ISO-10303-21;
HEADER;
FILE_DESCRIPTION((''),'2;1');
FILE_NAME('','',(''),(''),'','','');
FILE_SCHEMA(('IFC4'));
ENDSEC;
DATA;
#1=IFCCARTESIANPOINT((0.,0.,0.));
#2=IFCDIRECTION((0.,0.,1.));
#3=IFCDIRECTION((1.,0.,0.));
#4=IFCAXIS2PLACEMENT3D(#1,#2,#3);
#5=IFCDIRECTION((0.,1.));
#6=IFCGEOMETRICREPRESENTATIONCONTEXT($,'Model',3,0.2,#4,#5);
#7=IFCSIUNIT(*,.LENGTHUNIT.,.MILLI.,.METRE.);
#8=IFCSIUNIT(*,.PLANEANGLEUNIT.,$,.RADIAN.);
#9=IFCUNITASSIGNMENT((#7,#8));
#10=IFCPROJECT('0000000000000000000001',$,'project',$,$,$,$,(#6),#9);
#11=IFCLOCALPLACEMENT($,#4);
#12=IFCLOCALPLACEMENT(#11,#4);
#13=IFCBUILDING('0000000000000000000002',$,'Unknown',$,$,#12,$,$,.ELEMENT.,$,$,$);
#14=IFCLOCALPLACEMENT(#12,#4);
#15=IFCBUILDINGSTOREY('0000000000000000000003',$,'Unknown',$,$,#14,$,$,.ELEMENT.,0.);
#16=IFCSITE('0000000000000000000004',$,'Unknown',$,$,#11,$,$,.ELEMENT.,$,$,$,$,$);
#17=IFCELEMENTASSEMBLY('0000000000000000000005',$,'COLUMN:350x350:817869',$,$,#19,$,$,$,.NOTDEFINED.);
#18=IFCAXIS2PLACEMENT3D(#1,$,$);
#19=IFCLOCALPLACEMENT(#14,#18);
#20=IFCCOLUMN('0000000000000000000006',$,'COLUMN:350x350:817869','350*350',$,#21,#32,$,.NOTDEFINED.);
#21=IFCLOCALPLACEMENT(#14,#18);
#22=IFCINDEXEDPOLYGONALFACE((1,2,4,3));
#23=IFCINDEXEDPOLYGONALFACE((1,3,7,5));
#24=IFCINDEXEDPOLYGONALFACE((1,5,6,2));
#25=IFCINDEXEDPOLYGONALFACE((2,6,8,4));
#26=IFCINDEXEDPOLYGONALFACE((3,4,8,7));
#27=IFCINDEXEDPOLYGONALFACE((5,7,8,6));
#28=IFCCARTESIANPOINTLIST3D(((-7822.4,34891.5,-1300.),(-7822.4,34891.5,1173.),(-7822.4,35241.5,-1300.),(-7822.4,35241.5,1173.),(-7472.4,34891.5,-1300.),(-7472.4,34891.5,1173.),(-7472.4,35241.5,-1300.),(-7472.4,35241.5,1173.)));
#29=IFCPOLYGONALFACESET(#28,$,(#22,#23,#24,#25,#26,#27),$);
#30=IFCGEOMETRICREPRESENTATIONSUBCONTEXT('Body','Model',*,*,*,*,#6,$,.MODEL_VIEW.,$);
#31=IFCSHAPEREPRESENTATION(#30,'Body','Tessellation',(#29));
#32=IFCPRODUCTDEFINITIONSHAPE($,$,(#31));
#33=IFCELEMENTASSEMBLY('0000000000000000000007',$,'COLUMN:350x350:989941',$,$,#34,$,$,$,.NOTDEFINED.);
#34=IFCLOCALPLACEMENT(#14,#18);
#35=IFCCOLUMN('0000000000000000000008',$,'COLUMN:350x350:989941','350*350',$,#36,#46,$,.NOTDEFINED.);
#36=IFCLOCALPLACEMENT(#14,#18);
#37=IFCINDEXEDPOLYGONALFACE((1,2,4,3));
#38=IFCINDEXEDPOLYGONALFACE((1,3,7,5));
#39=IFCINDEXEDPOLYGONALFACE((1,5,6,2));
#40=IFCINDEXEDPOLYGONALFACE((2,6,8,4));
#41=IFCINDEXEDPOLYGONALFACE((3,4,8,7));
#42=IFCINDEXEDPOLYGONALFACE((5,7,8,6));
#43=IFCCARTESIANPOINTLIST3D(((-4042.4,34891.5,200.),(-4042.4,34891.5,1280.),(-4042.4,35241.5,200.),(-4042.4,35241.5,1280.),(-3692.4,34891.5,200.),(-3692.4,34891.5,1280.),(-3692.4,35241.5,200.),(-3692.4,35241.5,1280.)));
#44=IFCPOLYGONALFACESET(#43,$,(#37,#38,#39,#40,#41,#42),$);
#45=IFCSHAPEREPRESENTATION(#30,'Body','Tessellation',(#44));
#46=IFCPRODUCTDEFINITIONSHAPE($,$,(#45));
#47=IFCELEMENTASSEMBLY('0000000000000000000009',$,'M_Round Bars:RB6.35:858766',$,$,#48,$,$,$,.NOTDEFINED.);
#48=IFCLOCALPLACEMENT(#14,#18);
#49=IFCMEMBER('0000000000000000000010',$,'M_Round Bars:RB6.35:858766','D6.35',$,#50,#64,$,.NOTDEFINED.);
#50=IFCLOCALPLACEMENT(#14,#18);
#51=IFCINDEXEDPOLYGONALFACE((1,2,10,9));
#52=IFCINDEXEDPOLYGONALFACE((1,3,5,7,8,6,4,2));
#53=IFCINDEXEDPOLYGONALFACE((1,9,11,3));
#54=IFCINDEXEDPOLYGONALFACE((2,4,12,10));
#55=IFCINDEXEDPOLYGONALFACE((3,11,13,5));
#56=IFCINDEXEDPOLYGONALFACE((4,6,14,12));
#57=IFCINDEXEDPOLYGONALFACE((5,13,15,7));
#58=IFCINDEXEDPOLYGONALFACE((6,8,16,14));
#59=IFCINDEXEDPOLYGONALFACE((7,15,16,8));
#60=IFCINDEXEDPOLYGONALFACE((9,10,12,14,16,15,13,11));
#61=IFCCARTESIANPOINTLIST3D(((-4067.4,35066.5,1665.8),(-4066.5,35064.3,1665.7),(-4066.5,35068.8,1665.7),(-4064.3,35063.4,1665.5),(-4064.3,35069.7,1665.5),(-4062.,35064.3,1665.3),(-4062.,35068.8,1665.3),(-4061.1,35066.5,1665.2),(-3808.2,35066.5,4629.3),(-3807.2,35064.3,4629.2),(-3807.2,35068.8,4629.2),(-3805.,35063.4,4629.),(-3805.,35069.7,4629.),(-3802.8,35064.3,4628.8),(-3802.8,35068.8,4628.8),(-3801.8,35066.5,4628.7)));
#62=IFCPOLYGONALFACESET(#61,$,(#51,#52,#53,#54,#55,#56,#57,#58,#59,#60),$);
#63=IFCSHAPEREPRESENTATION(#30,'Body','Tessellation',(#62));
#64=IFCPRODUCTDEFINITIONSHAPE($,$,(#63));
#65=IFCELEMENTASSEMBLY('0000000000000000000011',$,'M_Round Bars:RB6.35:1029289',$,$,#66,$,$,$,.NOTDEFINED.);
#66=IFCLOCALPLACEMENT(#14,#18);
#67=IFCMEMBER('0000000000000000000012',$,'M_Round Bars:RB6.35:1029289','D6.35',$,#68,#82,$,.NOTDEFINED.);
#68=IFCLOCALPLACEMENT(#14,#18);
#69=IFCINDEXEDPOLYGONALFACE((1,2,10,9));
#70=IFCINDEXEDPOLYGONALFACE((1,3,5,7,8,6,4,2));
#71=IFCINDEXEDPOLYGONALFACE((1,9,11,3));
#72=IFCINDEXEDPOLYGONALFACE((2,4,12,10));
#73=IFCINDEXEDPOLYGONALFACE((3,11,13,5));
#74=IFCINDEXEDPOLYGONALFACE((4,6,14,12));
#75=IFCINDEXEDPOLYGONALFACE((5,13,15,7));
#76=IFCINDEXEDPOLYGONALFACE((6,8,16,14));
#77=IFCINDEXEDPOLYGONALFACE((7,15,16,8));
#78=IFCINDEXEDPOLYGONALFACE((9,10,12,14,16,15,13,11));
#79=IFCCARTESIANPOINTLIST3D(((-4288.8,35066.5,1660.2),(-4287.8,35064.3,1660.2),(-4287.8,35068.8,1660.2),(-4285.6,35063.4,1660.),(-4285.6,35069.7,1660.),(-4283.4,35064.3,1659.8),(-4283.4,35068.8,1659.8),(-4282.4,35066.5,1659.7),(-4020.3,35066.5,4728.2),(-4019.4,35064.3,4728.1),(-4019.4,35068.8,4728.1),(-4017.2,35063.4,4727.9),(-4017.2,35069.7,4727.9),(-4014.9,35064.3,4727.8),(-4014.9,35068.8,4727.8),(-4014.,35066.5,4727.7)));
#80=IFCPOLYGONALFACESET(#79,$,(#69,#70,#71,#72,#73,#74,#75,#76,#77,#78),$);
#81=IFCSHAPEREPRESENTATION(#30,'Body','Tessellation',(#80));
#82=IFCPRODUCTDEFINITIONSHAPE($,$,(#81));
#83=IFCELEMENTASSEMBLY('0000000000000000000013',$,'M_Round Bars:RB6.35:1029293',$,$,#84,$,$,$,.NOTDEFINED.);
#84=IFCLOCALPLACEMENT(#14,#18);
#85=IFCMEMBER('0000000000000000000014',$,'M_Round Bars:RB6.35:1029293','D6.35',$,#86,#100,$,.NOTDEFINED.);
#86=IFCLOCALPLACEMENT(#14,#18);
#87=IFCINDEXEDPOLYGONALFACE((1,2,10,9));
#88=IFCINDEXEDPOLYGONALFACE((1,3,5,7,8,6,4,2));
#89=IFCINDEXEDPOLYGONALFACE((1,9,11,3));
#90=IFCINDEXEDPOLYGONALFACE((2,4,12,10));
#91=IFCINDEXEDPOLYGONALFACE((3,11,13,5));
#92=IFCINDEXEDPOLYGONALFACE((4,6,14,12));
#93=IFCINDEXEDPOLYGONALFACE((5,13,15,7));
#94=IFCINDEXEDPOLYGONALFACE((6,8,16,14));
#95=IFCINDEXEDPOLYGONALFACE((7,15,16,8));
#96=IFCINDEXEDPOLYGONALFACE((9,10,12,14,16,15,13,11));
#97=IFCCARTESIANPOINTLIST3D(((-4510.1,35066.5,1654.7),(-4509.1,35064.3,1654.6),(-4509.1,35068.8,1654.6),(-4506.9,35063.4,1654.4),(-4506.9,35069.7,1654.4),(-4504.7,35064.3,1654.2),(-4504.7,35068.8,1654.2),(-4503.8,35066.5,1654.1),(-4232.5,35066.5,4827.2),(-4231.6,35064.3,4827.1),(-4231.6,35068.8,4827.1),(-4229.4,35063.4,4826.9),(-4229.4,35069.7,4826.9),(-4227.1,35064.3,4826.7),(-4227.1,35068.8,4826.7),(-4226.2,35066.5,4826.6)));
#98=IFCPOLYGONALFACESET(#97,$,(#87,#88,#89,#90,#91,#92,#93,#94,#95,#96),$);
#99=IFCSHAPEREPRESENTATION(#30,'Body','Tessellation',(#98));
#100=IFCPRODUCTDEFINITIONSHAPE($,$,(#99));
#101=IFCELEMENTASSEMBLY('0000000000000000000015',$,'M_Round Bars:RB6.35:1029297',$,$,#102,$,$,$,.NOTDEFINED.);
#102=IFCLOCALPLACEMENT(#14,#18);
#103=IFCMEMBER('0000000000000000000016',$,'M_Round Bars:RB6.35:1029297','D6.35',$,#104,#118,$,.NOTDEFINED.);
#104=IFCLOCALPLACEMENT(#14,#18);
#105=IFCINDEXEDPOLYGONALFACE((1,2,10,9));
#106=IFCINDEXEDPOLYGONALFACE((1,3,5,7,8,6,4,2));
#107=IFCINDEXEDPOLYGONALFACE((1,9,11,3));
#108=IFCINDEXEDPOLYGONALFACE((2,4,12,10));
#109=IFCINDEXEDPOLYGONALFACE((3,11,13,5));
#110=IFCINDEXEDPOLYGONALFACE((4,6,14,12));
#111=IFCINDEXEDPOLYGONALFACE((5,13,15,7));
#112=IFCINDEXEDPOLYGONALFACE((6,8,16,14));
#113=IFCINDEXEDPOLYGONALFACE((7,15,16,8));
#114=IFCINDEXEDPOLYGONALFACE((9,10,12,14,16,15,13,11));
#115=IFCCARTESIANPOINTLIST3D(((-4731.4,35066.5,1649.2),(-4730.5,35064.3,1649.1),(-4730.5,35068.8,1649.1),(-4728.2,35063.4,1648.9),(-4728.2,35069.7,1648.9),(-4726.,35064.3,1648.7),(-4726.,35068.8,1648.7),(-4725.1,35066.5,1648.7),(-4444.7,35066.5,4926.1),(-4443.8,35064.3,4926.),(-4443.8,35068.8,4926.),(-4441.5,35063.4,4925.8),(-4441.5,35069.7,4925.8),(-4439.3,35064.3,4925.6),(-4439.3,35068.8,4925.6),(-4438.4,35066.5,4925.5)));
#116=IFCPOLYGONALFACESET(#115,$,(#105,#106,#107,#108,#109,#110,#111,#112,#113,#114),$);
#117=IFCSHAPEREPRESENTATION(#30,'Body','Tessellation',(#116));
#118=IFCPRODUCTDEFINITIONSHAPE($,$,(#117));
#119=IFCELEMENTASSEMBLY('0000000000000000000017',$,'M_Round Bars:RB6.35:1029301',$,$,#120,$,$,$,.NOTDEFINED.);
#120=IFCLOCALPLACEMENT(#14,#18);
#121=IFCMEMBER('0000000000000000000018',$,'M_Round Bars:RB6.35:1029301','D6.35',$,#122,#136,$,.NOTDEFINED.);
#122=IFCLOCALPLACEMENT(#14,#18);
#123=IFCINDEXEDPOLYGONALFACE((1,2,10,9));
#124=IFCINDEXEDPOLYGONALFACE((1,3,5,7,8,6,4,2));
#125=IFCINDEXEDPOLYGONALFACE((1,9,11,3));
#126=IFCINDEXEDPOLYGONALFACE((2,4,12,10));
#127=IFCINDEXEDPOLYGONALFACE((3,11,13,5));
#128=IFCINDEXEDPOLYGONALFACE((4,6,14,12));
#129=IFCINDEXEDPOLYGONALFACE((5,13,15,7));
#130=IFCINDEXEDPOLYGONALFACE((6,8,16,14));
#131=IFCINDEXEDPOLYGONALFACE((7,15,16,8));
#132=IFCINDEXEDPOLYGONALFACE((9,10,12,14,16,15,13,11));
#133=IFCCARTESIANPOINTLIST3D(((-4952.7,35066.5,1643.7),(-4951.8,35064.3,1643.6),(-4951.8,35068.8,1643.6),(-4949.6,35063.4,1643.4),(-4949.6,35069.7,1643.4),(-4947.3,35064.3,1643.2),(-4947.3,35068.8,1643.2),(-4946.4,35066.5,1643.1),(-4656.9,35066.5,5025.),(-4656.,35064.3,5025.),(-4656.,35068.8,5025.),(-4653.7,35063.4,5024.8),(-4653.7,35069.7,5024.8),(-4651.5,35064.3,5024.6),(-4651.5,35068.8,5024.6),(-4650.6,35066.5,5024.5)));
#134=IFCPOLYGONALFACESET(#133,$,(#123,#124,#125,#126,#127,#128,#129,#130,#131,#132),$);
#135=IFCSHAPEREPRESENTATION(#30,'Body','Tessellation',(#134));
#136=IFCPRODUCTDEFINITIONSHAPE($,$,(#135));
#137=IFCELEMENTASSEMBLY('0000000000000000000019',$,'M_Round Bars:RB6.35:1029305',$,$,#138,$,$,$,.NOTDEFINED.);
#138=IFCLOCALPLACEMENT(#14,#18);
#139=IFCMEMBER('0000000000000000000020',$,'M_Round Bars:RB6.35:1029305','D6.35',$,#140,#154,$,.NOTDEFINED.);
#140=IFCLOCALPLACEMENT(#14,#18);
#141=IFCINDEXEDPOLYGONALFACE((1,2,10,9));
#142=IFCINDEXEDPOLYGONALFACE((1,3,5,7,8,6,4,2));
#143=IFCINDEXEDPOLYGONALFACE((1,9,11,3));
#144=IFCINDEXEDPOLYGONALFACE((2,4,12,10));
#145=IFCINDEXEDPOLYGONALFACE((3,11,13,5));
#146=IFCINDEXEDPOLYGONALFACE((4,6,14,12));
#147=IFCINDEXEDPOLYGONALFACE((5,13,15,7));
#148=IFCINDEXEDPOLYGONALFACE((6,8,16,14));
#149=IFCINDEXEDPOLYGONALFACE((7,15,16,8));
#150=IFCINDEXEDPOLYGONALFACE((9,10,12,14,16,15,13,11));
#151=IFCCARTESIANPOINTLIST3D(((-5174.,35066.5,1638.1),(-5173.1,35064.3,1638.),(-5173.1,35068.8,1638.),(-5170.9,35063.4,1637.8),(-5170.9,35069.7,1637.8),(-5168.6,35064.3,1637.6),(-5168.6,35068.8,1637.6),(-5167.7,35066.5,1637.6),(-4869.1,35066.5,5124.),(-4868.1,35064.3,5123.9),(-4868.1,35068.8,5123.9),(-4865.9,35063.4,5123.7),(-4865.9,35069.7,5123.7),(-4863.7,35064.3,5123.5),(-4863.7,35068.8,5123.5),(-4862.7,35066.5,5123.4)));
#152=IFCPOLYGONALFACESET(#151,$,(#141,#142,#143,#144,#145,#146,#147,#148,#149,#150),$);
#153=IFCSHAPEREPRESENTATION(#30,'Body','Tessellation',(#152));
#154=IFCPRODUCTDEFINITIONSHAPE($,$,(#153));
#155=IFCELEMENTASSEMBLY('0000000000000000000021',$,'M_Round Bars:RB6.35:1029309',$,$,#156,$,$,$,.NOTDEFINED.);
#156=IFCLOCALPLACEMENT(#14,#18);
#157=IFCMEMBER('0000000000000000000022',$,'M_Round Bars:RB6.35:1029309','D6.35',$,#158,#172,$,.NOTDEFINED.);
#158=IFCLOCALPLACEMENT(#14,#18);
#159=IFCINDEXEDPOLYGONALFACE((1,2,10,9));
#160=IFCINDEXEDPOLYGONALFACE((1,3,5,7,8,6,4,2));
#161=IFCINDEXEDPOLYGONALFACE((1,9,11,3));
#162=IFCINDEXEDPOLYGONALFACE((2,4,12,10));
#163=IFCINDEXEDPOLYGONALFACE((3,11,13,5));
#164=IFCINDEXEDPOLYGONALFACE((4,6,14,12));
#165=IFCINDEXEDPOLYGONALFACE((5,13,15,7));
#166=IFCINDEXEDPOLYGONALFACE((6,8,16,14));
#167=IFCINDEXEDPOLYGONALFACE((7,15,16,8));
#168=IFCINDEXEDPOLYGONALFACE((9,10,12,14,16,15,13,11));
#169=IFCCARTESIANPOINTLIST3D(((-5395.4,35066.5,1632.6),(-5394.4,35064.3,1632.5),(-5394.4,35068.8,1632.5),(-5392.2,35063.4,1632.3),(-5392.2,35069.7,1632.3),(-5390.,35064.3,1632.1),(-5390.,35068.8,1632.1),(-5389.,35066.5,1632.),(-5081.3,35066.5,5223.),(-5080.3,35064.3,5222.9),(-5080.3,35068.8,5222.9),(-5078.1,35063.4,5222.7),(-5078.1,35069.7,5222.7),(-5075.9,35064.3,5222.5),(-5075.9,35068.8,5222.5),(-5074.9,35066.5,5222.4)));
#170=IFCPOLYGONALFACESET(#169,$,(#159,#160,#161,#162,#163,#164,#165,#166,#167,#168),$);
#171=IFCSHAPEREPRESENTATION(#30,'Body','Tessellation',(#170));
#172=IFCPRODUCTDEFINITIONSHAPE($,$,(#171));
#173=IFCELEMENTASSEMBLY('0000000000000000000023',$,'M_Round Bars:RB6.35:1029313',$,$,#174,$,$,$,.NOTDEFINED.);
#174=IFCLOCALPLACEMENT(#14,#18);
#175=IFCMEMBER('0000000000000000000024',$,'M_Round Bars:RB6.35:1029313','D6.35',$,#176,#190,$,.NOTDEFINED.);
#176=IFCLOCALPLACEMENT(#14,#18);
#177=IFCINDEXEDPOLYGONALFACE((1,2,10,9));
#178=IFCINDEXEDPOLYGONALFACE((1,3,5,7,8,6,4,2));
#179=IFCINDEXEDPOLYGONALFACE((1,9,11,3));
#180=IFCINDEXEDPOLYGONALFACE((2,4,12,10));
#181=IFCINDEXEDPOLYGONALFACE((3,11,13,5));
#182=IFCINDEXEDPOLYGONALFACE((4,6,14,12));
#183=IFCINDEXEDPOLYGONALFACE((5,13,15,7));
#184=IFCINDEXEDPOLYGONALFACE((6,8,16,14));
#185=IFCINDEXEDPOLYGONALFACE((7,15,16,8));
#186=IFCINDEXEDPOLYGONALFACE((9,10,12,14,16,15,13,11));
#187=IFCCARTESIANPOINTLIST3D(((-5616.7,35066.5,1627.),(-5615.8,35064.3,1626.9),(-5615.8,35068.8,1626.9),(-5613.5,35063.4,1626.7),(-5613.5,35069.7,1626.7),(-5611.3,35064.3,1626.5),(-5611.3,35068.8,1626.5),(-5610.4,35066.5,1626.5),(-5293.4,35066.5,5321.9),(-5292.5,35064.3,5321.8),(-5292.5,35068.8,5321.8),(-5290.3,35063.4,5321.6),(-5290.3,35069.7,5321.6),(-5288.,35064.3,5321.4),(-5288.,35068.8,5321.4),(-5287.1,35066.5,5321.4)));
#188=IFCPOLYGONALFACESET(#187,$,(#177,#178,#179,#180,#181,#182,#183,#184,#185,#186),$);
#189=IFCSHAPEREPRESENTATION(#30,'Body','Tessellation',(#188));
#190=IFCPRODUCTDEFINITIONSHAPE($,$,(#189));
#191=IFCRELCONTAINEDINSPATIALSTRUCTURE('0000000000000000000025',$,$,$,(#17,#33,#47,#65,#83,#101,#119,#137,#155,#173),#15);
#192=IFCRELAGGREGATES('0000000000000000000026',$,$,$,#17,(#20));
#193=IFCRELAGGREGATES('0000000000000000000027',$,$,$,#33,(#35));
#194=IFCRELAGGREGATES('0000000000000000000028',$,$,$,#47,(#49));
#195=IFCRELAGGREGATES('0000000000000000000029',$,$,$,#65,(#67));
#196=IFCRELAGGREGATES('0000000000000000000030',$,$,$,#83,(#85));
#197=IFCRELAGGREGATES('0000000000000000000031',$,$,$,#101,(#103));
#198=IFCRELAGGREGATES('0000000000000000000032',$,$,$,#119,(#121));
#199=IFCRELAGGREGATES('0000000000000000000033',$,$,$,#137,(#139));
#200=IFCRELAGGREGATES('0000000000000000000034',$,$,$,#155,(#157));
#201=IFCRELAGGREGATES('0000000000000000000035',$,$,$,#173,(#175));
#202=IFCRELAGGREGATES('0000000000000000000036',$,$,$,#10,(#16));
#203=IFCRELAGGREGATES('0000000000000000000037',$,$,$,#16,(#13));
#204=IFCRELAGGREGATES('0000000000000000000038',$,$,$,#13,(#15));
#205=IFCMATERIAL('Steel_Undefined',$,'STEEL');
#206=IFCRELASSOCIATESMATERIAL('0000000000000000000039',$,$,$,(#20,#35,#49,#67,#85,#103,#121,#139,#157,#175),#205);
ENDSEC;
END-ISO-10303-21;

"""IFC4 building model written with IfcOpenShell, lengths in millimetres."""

from ifc_helpers import new_model, si_unit, direction, frame, origin_with_axes, place, context, subcontext, project, spatial, line, indexed_curve, outline, extrude, material, element, aggregate, save


model = new_model("IFC4")

# Units and contexts
model_context = context("Model", 3, precision=0.2, world=origin_with_axes(), true_north=direction((0.0, 1.0)))
body_context = subcontext(model_context, "Body", "Model", "MODEL_VIEW")
ifc_project = project(units=[si_unit("LENGTHUNIT", "METRE", prefix="MILLI"), si_unit("PLANEANGLEUNIT", "RADIAN")], contexts=[model_context])

# Site, building, storey
site_placement = place(None, origin_with_axes())
site = spatial("IfcSite", under=ifc_project, at=site_placement, Name="Unknown", CompositionType="ELEMENT")
building_placement = place(site_placement, origin_with_axes())
building = spatial("IfcBuilding", under=site, at=building_placement, Name="Unknown", CompositionType="ELEMENT")
storey_placement = place(building_placement, origin_with_axes())
storey = spatial("IfcBuildingStorey", under=building, at=storey_placement, Name="Unknown", CompositionType="ELEMENT", Elevation=0.0)

# Element assemblies, columns
assembly_1_placement = place(storey_placement, frame((-7647.4, 35066.5, -1300.0), z_axis=(1.0, 0.0, 0.0), x_axis=(0.0, 0.0, 1.0)))
assembly_1 = element("IfcElementAssembly", 1, at=assembly_1_placement, inside=storey, Name="COLUMN:350x350:817869", PredefinedType="NOTDEFINED")
ifc_material_1 = material(Name="Steel_Undefined", Category="STEEL")
column_1_placement = place(assembly_1_placement, origin_with_axes())
column_1 = element("IfcColumn", 2, at=column_1_placement, material=ifc_material_1, Name="COLUMN:350x350:817869", Description="350*350", PredefinedType="NOTDEFINED", context=body_context, shape_type="SolidModel", body=[
    extrude(outline(indexed_curve([(-175.0, -175.0), (175.0, -175.0), (175.0, 175.0), (-175.0, 175.0)], segments=[line(1, 2, 3, 4, 1)])), frame((0.0, 0.0, 0.0), z_axis=(-1.0, 0.0, 0.0), x_axis=(0.0, 0.0, 1.0)), (0.0, 0.0, -1.0), 2473.0),
])
aggregate(assembly_1, [column_1])
assembly_2_placement = place(storey_placement, frame((-3867.4, 35066.5, 200.0), z_axis=(1.0, 0.0, 0.0), x_axis=(0.0, 0.0, 1.0)))
assembly_2 = element("IfcElementAssembly", 3, at=assembly_2_placement, inside=storey, Name="COLUMN:350x350:989941", PredefinedType="NOTDEFINED")
column_2_placement = place(assembly_2_placement, origin_with_axes())
column_2 = element("IfcColumn", 4, at=column_2_placement, material=ifc_material_1, Name="COLUMN:350x350:989941", Description="350*350", PredefinedType="NOTDEFINED", context=body_context, shape_type="SolidModel", body=[
    extrude(outline(indexed_curve([(-175.0, -175.0), (175.0, -175.0), (175.0, 175.0), (-175.0, 175.0)], segments=[line(1, 2, 3, 4, 1)])), frame((0.0, 0.0, 0.0), z_axis=(-1.0, 0.0, 0.0), x_axis=(0.0, 0.0, 1.0)), (0.0, 0.0, -1.0), 1080.0),
])
aggregate(assembly_2, [column_2])

# Element assemblies, members
assembly_3_placement = place(storey_placement, frame((-3805.0, 35066.5, 4629.0), z_axis=(0.0, -1.0, 0.0), x_axis=(-0.087156, 0.0, -0.996195)))
assembly_3 = element("IfcElementAssembly", 5, at=assembly_3_placement, inside=storey, Name="M_Round Bars:RB6.35:858766", PredefinedType="NOTDEFINED")
member_1_placement = place(assembly_3_placement, origin_with_axes())
member_1 = element("IfcMember", 6, at=member_1_placement, material=ifc_material_1, Name="M_Round Bars:RB6.35:858766", Description="D6.35", PredefinedType="NOTDEFINED", context=body_context, shape_type="SolidModel", body=[
    extrude(outline(indexed_curve([(3.2, 0.0), (2.2, 2.2), (0.0, 3.2), (-2.2, 2.2), (-3.2, 0.0), (-2.2, -2.2), (0.0, -3.2), (2.2, -2.2)], segments=[line(1, 2, 3, 4, 5, 6, 7, 8, 1)])), frame((0.0, 0.0, 0.0), z_axis=(-1.0, 0.0, 0.0), x_axis=(0.0, 0.0, 1.0)), (0.0, 0.0, -1.0), 2974.8),
])
aggregate(assembly_3, [member_1])
assembly_4_placement = place(storey_placement, frame((-4017.2, 35066.5, 4727.9), z_axis=(0.0, -1.0, 0.0), x_axis=(-0.087156, 0.0, -0.996195)))
assembly_4 = element("IfcElementAssembly", 7, at=assembly_4_placement, inside=storey, Name="M_Round Bars:RB6.35:1029289", PredefinedType="NOTDEFINED")
member_2_placement = place(assembly_4_placement, origin_with_axes())
member_2 = element("IfcMember", 8, at=member_2_placement, material=ifc_material_1, Name="M_Round Bars:RB6.35:1029289", Description="D6.35", PredefinedType="NOTDEFINED", context=body_context, shape_type="SolidModel", body=[
    extrude(outline(indexed_curve([(3.2, 0.0), (2.2, 2.2), (0.0, 3.2), (-2.2, 2.2), (-3.2, 0.0), (-2.2, -2.2), (0.0, -3.2), (2.2, -2.2)], segments=[line(1, 2, 3, 4, 5, 6, 7, 8, 1)])), frame((0.0, 0.0, 0.0), z_axis=(-1.0, 0.0, 0.0), x_axis=(0.0, 0.0, 1.0)), (0.0, 0.0, -1.0), 3079.7),
])
aggregate(assembly_4, [member_2])
assembly_5_placement = place(storey_placement, frame((-4229.4, 35066.5, 4826.9), z_axis=(0.0, -1.0, 0.0), x_axis=(-0.087156, 0.0, -0.996195)))
assembly_5 = element("IfcElementAssembly", 9, at=assembly_5_placement, inside=storey, Name="M_Round Bars:RB6.35:1029293", PredefinedType="NOTDEFINED")
member_3_placement = place(assembly_5_placement, origin_with_axes())
member_3 = element("IfcMember", 10, at=member_3_placement, material=ifc_material_1, Name="M_Round Bars:RB6.35:1029293", Description="D6.35", PredefinedType="NOTDEFINED", context=body_context, shape_type="SolidModel", body=[
    extrude(outline(indexed_curve([(3.2, 0.0), (2.2, 2.2), (0.0, 3.2), (-2.2, 2.2), (-3.2, 0.0), (-2.2, -2.2), (0.0, -3.2), (2.2, -2.2)], segments=[line(1, 2, 3, 4, 5, 6, 7, 8, 1)])), frame((0.0, 0.0, 0.0), z_axis=(-1.0, 0.0, 0.0), x_axis=(0.0, 0.0, 1.0)), (0.0, 0.0, -1.0), 3184.6),
])
aggregate(assembly_5, [member_3])
assembly_6_placement = place(storey_placement, frame((-4441.5, 35066.5, 4925.8), z_axis=(0.0, -1.0, 0.0), x_axis=(-0.087156, 0.0, -0.996195)))
assembly_6 = element("IfcElementAssembly", 11, at=assembly_6_placement, inside=storey, Name="M_Round Bars:RB6.35:1029297", PredefinedType="NOTDEFINED")
member_4_placement = place(assembly_6_placement, origin_with_axes())
member_4 = element("IfcMember", 12, at=member_4_placement, material=ifc_material_1, Name="M_Round Bars:RB6.35:1029297", Description="D6.35", PredefinedType="NOTDEFINED", context=body_context, shape_type="SolidModel", body=[
    extrude(outline(indexed_curve([(3.2, 0.0), (2.2, 2.2), (0.0, 3.2), (-2.2, 2.2), (-3.2, 0.0), (-2.2, -2.2), (0.0, -3.2), (2.2, -2.2)], segments=[line(1, 2, 3, 4, 5, 6, 7, 8, 1)])), frame((0.0, 0.0, 0.0), z_axis=(-1.0, 0.0, 0.0), x_axis=(0.0, 0.0, 1.0)), (0.0, 0.0, -1.0), 3289.4),
])
aggregate(assembly_6, [member_4])
assembly_7_placement = place(storey_placement, frame((-4653.7, 35066.5, 5024.8), z_axis=(0.0, -1.0, 0.0), x_axis=(-0.087156, 0.0, -0.996195)))
assembly_7 = element("IfcElementAssembly", 13, at=assembly_7_placement, inside=storey, Name="M_Round Bars:RB6.35:1029301", PredefinedType="NOTDEFINED")
member_5_placement = place(assembly_7_placement, origin_with_axes())
member_5 = element("IfcMember", 14, at=member_5_placement, material=ifc_material_1, Name="M_Round Bars:RB6.35:1029301", Description="D6.35", PredefinedType="NOTDEFINED", context=body_context, shape_type="SolidModel", body=[
    extrude(outline(indexed_curve([(3.2, 0.0), (2.2, 2.2), (0.0, 3.2), (-2.2, 2.2), (-3.2, 0.0), (-2.2, -2.2), (0.0, -3.2), (2.2, -2.2)], segments=[line(1, 2, 3, 4, 5, 6, 7, 8, 1)])), frame((0.0, 0.0, 0.0), z_axis=(-1.0, 0.0, 0.0), x_axis=(0.0, 0.0, 1.0)), (0.0, 0.0, -1.0), 3394.3),
])
aggregate(assembly_7, [member_5])
assembly_8_placement = place(storey_placement, frame((-4865.9, 35066.5, 5123.7), z_axis=(0.0, -1.0, 0.0), x_axis=(-0.087156, 0.0, -0.996195)))
assembly_8 = element("IfcElementAssembly", 15, at=assembly_8_placement, inside=storey, Name="M_Round Bars:RB6.35:1029305", PredefinedType="NOTDEFINED")
member_6_placement = place(assembly_8_placement, origin_with_axes())
member_6 = element("IfcMember", 16, at=member_6_placement, material=ifc_material_1, Name="M_Round Bars:RB6.35:1029305", Description="D6.35", PredefinedType="NOTDEFINED", context=body_context, shape_type="SolidModel", body=[
    extrude(outline(indexed_curve([(3.2, 0.0), (2.2, 2.2), (0.0, 3.2), (-2.2, 2.2), (-3.2, 0.0), (-2.2, -2.2), (0.0, -3.2), (2.2, -2.2)], segments=[line(1, 2, 3, 4, 5, 6, 7, 8, 1)])), frame((0.0, 0.0, 0.0), z_axis=(-1.0, 0.0, 0.0), x_axis=(0.0, 0.0, 1.0)), (0.0, 0.0, -1.0), 3499.2),
])
aggregate(assembly_8, [member_6])
assembly_9_placement = place(storey_placement, frame((-5078.1, 35066.5, 5222.7), z_axis=(0.0, -1.0, 0.0), x_axis=(-0.087156, 0.0, -0.996195)))
assembly_9 = element("IfcElementAssembly", 17, at=assembly_9_placement, inside=storey, Name="M_Round Bars:RB6.35:1029309", PredefinedType="NOTDEFINED")
member_7_placement = place(assembly_9_placement, origin_with_axes())
member_7 = element("IfcMember", 18, at=member_7_placement, material=ifc_material_1, Name="M_Round Bars:RB6.35:1029309", Description="D6.35", PredefinedType="NOTDEFINED", context=body_context, shape_type="SolidModel", body=[
    extrude(outline(indexed_curve([(3.2, 0.0), (2.2, 2.2), (0.0, 3.2), (-2.2, 2.2), (-3.2, 0.0), (-2.2, -2.2), (0.0, -3.2), (2.2, -2.2)], segments=[line(1, 2, 3, 4, 5, 6, 7, 8, 1)])), frame((0.0, 0.0, 0.0), z_axis=(-1.0, 0.0, 0.0), x_axis=(0.0, 0.0, 1.0)), (0.0, 0.0, -1.0), 3604.1),
])
aggregate(assembly_9, [member_7])
assembly_10_placement = place(storey_placement, frame((-5290.3, 35066.5, 5321.6), z_axis=(0.0, -1.0, 0.0), x_axis=(-0.087156, 0.0, -0.996195)))
assembly_10 = element("IfcElementAssembly", 19, at=assembly_10_placement, inside=storey, Name="M_Round Bars:RB6.35:1029313", PredefinedType="NOTDEFINED")
member_8_placement = place(assembly_10_placement, origin_with_axes())
member_8 = element("IfcMember", 20, at=member_8_placement, material=ifc_material_1, Name="M_Round Bars:RB6.35:1029313", Description="D6.35", PredefinedType="NOTDEFINED", context=body_context, shape_type="SolidModel", body=[
    extrude(outline(indexed_curve([(3.2, 0.0), (2.2, 2.2), (0.0, 3.2), (-2.2, 2.2), (-3.2, 0.0), (-2.2, -2.2), (0.0, -3.2), (2.2, -2.2)], segments=[line(1, 2, 3, 4, 5, 6, 7, 8, 1)])), frame((0.0, 0.0, 0.0), z_axis=(-1.0, 0.0, 0.0), x_axis=(0.0, 0.0, 1.0)), (0.0, 0.0, -1.0), 3709.0),
])
aggregate(assembly_10, [member_8])

save(model, "model.ifc")
